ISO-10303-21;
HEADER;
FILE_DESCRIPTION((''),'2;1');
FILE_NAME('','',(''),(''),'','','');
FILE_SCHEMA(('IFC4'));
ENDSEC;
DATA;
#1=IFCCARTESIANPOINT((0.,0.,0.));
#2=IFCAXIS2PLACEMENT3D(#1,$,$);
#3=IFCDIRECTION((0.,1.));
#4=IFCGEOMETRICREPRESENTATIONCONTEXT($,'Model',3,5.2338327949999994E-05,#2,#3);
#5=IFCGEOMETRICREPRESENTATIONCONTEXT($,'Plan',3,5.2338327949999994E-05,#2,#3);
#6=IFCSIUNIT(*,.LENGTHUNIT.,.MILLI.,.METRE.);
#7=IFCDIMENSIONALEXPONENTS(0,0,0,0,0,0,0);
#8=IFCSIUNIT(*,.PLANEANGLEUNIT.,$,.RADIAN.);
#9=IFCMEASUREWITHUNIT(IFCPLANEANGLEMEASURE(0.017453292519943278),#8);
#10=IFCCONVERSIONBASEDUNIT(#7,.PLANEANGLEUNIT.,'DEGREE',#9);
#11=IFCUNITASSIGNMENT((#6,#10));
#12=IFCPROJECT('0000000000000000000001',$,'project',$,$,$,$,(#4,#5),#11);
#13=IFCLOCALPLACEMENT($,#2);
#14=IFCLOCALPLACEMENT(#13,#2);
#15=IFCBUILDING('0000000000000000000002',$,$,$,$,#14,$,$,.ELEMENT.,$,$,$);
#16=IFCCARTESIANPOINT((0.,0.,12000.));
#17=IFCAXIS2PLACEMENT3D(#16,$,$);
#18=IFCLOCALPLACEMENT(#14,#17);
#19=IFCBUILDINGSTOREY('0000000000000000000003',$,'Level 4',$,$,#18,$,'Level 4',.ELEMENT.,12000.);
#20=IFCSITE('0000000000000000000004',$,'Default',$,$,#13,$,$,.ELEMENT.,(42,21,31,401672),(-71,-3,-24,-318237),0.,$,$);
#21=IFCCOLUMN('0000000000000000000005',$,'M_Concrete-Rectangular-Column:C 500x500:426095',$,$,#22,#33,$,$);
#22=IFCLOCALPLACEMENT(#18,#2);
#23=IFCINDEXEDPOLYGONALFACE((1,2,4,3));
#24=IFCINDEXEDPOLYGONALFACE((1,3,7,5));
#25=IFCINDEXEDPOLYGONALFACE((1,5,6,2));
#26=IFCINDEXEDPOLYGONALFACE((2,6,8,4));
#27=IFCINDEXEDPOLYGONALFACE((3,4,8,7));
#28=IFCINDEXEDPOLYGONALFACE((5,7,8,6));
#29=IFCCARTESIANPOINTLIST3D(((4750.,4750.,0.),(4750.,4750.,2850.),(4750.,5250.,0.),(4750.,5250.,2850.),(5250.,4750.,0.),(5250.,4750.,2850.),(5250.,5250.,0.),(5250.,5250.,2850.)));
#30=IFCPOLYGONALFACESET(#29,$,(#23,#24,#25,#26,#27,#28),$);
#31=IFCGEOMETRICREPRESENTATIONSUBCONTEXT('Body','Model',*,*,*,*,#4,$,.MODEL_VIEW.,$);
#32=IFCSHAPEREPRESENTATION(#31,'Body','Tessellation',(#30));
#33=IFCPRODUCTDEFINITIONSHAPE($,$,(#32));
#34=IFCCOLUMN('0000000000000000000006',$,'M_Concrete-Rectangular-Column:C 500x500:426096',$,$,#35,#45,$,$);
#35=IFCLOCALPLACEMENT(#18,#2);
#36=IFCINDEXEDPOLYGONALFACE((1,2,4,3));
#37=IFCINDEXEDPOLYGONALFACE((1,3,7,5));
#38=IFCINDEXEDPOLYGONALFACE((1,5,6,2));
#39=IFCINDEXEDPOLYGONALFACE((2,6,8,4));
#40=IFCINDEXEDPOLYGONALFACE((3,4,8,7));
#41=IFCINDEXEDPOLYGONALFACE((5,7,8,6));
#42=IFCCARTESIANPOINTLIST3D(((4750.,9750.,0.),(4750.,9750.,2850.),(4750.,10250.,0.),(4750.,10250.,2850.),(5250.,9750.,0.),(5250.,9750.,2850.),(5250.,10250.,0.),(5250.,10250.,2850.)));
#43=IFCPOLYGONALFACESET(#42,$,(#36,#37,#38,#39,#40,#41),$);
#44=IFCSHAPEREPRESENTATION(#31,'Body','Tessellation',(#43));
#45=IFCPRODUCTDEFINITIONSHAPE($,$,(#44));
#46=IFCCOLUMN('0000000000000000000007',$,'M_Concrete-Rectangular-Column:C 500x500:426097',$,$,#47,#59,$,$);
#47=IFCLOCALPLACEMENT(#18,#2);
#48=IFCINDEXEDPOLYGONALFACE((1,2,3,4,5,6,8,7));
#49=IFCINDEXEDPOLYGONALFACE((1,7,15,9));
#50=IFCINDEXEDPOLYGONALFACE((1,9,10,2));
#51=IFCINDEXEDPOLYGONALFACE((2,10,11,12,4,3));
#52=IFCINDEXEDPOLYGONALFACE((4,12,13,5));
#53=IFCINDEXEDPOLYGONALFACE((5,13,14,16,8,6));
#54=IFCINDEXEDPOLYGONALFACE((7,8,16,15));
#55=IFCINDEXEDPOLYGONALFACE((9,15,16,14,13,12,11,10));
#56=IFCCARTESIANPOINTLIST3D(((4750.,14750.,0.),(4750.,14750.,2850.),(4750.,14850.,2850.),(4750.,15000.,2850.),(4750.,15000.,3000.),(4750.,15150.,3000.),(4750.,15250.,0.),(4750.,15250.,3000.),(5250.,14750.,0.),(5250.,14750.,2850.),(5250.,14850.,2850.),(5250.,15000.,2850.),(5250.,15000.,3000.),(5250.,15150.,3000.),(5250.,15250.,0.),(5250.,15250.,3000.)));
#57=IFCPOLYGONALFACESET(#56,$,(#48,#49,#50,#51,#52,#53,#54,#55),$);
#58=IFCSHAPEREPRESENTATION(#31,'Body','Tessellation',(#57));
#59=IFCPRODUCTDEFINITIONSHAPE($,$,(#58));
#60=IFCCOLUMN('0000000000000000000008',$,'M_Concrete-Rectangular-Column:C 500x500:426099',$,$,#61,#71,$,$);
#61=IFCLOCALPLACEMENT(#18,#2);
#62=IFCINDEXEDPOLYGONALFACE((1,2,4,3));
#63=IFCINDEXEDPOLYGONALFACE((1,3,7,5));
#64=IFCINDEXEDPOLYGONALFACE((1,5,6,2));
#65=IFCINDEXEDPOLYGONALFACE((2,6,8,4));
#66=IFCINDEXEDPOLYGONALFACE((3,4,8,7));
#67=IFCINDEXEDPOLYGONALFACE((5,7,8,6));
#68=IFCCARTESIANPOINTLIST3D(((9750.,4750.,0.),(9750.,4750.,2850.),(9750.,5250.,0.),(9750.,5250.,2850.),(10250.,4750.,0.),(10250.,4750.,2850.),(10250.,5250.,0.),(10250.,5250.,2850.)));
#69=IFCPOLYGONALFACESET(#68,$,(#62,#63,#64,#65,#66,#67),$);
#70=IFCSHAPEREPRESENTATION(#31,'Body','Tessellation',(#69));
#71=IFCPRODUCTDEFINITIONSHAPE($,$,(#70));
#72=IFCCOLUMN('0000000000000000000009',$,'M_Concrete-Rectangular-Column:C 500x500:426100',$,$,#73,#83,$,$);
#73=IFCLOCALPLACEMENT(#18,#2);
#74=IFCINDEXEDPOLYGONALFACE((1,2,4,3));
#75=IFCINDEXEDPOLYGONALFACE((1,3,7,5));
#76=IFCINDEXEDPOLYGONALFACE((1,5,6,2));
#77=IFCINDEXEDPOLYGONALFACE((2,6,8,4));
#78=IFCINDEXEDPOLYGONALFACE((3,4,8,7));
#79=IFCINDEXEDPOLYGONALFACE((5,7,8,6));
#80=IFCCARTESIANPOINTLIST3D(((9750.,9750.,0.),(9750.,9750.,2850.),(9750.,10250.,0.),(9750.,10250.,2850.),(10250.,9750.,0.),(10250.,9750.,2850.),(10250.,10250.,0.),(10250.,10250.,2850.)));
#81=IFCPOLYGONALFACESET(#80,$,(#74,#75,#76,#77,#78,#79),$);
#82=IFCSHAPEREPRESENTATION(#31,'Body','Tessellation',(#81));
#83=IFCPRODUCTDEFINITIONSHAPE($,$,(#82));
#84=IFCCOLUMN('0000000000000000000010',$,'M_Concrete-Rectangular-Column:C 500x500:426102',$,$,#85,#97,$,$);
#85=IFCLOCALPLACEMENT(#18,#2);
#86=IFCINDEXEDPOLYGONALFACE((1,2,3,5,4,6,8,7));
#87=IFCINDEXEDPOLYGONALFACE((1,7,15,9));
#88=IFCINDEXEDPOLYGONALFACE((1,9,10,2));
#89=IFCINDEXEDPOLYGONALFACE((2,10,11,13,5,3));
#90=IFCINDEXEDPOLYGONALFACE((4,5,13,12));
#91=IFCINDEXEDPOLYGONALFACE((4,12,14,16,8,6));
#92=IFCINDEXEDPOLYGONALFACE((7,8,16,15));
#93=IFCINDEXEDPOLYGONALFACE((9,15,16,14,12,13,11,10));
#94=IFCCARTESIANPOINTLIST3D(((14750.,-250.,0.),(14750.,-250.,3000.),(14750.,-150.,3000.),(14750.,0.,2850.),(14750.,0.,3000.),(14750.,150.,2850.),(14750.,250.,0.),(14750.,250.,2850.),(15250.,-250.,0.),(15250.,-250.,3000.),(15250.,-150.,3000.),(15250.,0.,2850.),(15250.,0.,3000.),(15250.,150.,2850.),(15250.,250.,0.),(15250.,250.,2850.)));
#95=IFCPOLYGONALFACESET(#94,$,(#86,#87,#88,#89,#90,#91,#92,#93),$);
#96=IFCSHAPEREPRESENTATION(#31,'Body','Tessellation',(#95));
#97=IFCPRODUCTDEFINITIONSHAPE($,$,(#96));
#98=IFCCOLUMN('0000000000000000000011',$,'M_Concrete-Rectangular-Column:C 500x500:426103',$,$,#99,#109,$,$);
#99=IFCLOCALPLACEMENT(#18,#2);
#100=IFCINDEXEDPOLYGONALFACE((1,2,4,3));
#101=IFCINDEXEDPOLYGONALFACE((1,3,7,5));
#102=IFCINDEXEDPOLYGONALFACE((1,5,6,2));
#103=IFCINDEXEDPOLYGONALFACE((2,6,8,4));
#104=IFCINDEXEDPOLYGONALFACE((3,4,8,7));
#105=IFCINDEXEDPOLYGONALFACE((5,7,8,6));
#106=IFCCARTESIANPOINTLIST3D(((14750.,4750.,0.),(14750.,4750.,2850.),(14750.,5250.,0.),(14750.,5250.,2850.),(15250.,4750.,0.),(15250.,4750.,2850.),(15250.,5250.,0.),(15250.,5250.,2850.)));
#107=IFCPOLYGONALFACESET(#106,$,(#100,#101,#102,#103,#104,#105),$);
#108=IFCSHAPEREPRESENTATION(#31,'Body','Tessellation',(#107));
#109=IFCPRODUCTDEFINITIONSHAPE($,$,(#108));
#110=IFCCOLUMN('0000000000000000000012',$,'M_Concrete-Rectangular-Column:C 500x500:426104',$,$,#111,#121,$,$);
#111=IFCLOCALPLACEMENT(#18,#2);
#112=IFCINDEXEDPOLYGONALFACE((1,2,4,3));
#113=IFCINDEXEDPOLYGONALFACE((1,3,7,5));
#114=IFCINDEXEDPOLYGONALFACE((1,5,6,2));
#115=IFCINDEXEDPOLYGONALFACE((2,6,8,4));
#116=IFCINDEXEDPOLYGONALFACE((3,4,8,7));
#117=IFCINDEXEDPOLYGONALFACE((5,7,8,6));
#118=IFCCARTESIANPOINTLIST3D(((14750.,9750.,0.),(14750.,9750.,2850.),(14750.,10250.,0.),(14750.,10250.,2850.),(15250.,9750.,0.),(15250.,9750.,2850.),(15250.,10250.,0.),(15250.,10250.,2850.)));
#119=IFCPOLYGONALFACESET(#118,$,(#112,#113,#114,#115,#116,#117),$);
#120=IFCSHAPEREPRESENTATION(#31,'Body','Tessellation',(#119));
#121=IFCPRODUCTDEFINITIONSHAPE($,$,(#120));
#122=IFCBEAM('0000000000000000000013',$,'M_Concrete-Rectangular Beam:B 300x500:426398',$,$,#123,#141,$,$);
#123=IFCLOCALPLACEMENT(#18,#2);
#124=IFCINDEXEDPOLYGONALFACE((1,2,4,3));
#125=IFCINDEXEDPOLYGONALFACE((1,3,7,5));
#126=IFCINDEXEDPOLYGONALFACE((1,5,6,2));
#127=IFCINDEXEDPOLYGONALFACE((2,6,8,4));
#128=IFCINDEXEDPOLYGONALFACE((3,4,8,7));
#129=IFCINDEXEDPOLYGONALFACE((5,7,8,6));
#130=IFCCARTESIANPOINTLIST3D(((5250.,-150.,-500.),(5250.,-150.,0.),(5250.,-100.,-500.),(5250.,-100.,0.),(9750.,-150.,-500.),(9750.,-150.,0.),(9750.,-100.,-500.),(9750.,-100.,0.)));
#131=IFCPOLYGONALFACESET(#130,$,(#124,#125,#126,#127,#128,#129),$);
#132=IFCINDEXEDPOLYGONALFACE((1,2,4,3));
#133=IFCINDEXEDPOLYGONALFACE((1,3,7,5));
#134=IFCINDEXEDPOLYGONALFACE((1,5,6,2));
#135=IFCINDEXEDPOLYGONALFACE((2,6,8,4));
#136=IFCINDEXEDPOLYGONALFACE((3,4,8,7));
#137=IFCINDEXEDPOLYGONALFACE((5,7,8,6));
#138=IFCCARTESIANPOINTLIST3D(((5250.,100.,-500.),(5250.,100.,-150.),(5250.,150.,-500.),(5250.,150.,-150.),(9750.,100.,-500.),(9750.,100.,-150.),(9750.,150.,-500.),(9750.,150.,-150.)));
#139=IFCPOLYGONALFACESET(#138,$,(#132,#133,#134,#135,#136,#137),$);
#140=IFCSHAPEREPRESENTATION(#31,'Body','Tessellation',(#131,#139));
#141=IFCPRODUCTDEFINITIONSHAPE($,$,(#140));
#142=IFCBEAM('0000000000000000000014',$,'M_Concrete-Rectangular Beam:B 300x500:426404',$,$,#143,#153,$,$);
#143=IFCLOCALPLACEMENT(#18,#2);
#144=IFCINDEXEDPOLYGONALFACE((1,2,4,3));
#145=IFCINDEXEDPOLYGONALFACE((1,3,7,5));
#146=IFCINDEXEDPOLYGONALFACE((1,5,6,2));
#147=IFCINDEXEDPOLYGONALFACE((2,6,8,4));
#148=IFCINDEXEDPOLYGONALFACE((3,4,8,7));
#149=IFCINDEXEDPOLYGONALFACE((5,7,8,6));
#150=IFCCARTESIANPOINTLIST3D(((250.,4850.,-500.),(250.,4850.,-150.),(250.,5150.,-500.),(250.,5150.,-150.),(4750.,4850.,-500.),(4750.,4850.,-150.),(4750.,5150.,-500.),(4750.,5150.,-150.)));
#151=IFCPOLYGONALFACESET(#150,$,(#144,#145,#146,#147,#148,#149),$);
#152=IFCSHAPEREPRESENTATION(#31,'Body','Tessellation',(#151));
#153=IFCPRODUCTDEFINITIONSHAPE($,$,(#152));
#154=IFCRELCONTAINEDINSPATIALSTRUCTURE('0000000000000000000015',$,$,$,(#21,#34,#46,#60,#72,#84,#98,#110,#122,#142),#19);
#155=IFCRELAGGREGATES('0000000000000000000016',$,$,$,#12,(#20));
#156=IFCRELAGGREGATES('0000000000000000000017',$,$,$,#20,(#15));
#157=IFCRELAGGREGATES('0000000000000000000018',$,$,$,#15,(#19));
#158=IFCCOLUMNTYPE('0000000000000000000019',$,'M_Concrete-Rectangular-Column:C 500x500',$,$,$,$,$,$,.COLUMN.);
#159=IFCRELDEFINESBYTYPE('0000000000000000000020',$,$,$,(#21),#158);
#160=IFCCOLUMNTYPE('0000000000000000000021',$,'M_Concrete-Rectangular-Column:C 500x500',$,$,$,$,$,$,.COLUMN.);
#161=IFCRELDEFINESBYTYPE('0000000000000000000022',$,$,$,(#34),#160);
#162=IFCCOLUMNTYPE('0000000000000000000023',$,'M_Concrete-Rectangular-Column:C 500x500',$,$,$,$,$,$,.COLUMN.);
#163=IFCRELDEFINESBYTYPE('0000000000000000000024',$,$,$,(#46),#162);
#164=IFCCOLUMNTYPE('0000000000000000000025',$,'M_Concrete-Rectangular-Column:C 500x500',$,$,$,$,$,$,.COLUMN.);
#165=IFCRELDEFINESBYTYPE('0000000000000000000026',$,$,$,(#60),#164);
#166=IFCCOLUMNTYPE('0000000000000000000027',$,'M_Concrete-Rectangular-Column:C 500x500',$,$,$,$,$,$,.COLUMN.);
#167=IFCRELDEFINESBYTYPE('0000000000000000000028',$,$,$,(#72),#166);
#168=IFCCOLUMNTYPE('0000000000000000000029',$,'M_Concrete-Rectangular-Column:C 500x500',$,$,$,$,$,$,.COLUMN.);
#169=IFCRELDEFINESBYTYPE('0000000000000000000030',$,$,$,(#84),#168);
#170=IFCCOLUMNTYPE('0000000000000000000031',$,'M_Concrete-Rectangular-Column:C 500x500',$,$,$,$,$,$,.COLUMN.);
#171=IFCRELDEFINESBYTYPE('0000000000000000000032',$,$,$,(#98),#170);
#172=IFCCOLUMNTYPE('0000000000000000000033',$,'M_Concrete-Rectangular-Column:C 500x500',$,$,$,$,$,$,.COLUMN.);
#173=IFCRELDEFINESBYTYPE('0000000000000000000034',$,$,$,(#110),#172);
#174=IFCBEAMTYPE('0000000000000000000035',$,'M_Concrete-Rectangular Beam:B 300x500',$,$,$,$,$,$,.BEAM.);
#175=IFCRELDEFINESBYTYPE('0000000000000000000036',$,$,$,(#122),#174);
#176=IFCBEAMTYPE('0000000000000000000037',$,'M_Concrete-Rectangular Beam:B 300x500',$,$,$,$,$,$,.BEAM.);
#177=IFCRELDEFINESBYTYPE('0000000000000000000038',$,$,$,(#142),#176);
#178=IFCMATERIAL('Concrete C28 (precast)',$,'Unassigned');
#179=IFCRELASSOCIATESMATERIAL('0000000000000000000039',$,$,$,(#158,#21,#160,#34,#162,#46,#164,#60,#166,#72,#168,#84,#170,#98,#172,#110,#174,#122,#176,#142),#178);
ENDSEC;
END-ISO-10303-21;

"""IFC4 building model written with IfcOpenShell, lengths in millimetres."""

from ifc_helpers import new_model, entity, si_unit, converted_unit, direction, frame, origin, place, context, subcontext, project, spatial, indexed_curve, outline, extrude, source, transform, mapped, material, type_object, type_shapes, element, save


model = new_model("IFC4")

# Units and contexts
model_context = context("Model", 3, precision=5.2338327949999994e-05, world=origin(), true_north=direction((0.0, 1.0)))
plan_context = context("Plan", 3, precision=5.2338327949999994e-05, world=origin(), true_north=direction((0.0, 1.0)))
body_context = subcontext(model_context, "Body", "Model", "MODEL_VIEW")
ifc_project = project(units=[si_unit("LENGTHUNIT", "METRE", prefix="MILLI"), converted_unit("PLANEANGLEUNIT", "DEGREE", entity("IfcPlaneAngleMeasure", 0.017453292519943278), si_unit("PLANEANGLEUNIT", "RADIAN"), dimensions=[0, 0, 0, 0, 0, 0, 0])], contexts=[model_context, plan_context])

# Site, building, storey
site_placement = place(None, origin())
site = spatial("IfcSite", under=ifc_project, at=site_placement, Name="Default", CompositionType="ELEMENT", RefLatitude=(42, 21, 31, 401672), RefLongitude=(-71, -3, -24, -318237), RefElevation=0.0)
building_placement = place(site_placement, origin())
building = spatial("IfcBuilding", under=site, at=building_placement, CompositionType="ELEMENT")
storey_placement = place(building_placement, frame((0.0, 0.0, 12000.0)))
storey = spatial("IfcBuildingStorey", under=building, at=storey_placement, Name="Level 4", LongName="Level 4", CompositionType="ELEMENT", Elevation=12000.0)

# Columns
ifc_material = material(Name="Concrete C28 (precast)", Category="Unassigned")
column_type_1 = type_object("IfcColumnType", Name="M_Concrete-Rectangular-Column:C 500x500", PredefinedType="COLUMN", material=ifc_material)
shared_shape_1 = source(origin(), body_context, "Body", "SweptSolid", [
    extrude(outline(indexed_curve([(-250.0, -250.0), (250.0, -250.0), (250.0, 250.0), (-250.0, 250.0), (-250.0, -250.0)], self_intersect=False)), frame((5000.0, 5000.0, 12000.0), z_axis=(0.0, 0.0, 1.0), x_axis=(-1.0, 0.0, 0.0)), (0.0, 0.0, 1.0), 2850.0),
])
type_shapes(column_type_1, [shared_shape_1])
column_1_placement = place(storey_placement, frame((0.0, 0.0, -12000.0)))
element("IfcColumn", 1, at=column_1_placement, inside=storey, type_object=column_type_1, material=ifc_material, Name="M_Concrete-Rectangular-Column:C 500x500:426095", context=body_context, shape_type="MappedRepresentation", body=[
    mapped(shared_shape_1, transform((0.0, 0.0, 0.0), scale=1.0)),
])
column_type_2 = type_object("IfcColumnType", Name="M_Concrete-Rectangular-Column:C 500x500", PredefinedType="COLUMN", material=ifc_material)
shared_shape_2 = source(origin(), body_context, "Body", "SweptSolid", [
    extrude(outline(indexed_curve([(-250.0, -250.0), (250.0, -250.0), (250.0, 250.0), (-250.0, 250.0), (-250.0, -250.0)], self_intersect=False)), frame((5000.0, 10000.0, 12000.0), z_axis=(0.0, 0.0, 1.0), x_axis=(-1.0, 0.0, 0.0)), (0.0, 0.0, 1.0), 2850.0),
])
type_shapes(column_type_2, [shared_shape_2])
column_2_placement = place(storey_placement, frame((0.0, 0.0, -12000.0)))
element("IfcColumn", 2, at=column_2_placement, inside=storey, type_object=column_type_2, material=ifc_material, Name="M_Concrete-Rectangular-Column:C 500x500:426096", context=body_context, shape_type="MappedRepresentation", body=[
    mapped(shared_shape_2, transform((0.0, 0.0, 0.0), scale=1.0)),
])
column_type_3 = type_object("IfcColumnType", Name="M_Concrete-Rectangular-Column:C 500x500", PredefinedType="COLUMN", material=ifc_material)
shared_shape_3 = source(origin(), body_context, "Body", "SweptSolid", [
    extrude(outline(indexed_curve([(-2193.8, -250.0), (806.2, -250.0), (806.2, -150.0), (806.2, 0.0), (656.2, 0.0), (656.2, 150.0), (656.2, 250.0), (-2193.8, 250.0), (-2193.8, -250.0)], self_intersect=False)), frame((4750.0, 15000.0, 14193.8), z_axis=(1.0, 0.0, 0.0), x_axis=(0.0, 0.0, 1.0)), (0.0, 0.0, 1.0), 500.0),
])
type_shapes(column_type_3, [shared_shape_3])
column_3_placement = place(storey_placement, frame((0.0, 0.0, -12000.0)))
element("IfcColumn", 3, at=column_3_placement, inside=storey, type_object=column_type_3, material=ifc_material, Name="M_Concrete-Rectangular-Column:C 500x500:426097", context=body_context, shape_type="MappedRepresentation", body=[
    mapped(shared_shape_3, transform((0.0, 0.0, 0.0), scale=1.0)),
])
column_type_4 = type_object("IfcColumnType", Name="M_Concrete-Rectangular-Column:C 500x500", PredefinedType="COLUMN", material=ifc_material)
shared_shape_4 = source(origin(), body_context, "Body", "SweptSolid", [
    extrude(outline(indexed_curve([(-250.0, -250.0), (250.0, -250.0), (250.0, 250.0), (-250.0, 250.0), (-250.0, -250.0)], self_intersect=False)), frame((10000.0, 5000.0, 12000.0), z_axis=(0.0, 0.0, 1.0), x_axis=(-1.0, 0.0, 0.0)), (0.0, 0.0, 1.0), 2850.0),
])
type_shapes(column_type_4, [shared_shape_4])
column_4_placement = place(storey_placement, frame((0.0, 0.0, -12000.0)))
element("IfcColumn", 4, at=column_4_placement, inside=storey, type_object=column_type_4, material=ifc_material, Name="M_Concrete-Rectangular-Column:C 500x500:426099", context=body_context, shape_type="MappedRepresentation", body=[
    mapped(shared_shape_4, transform((0.0, 0.0, 0.0), scale=1.0)),
])
column_type_5 = type_object("IfcColumnType", Name="M_Concrete-Rectangular-Column:C 500x500", PredefinedType="COLUMN", material=ifc_material)
shared_shape_5 = source(origin(), body_context, "Body", "SweptSolid", [
    extrude(outline(indexed_curve([(-250.0, -250.0), (250.0, -250.0), (250.0, 250.0), (-250.0, 250.0), (-250.0, -250.0)], self_intersect=False)), frame((10000.0, 10000.0, 12000.0), z_axis=(0.0, 0.0, 1.0), x_axis=(-1.0, 0.0, 0.0)), (0.0, 0.0, 1.0), 2850.0),
])
type_shapes(column_type_5, [shared_shape_5])
column_5_placement = place(storey_placement, frame((0.0, 0.0, -12000.0)))
element("IfcColumn", 5, at=column_5_placement, inside=storey, type_object=column_type_5, material=ifc_material, Name="M_Concrete-Rectangular-Column:C 500x500:426100", context=body_context, shape_type="MappedRepresentation", body=[
    mapped(shared_shape_5, transform((0.0, 0.0, 0.0), scale=1.0)),
])
column_type_6 = type_object("IfcColumnType", Name="M_Concrete-Rectangular-Column:C 500x500", PredefinedType="COLUMN", material=ifc_material)
shared_shape_6 = source(origin(), body_context, "Body", "SweptSolid", [
    extrude(outline(indexed_curve([(-2193.7, -250.0), (656.3, -250.0), (656.3, -150.0), (656.2, 0.0), (806.3, 0.0), (806.3, 150.0), (806.3, 250.0), (-2193.7, 250.0), (-2193.7, -250.0)], self_intersect=False)), frame((14750.0, 0.0, 14193.7), z_axis=(1.0, 0.0, 0.0), x_axis=(0.0, 0.0, 1.0)), (0.0, 0.0, 1.0), 500.0),
])
type_shapes(column_type_6, [shared_shape_6])
column_6_placement = place(storey_placement, frame((0.0, 0.0, -12000.0)))
element("IfcColumn", 6, at=column_6_placement, inside=storey, type_object=column_type_6, material=ifc_material, Name="M_Concrete-Rectangular-Column:C 500x500:426102", context=body_context, shape_type="MappedRepresentation", body=[
    mapped(shared_shape_6, transform((0.0, 0.0, 0.0), scale=1.0)),
])
column_type_7 = type_object("IfcColumnType", Name="M_Concrete-Rectangular-Column:C 500x500", PredefinedType="COLUMN", material=ifc_material)
shared_shape_7 = source(origin(), body_context, "Body", "SweptSolid", [
    extrude(outline(indexed_curve([(-250.0, -250.0), (250.0, -250.0), (250.0, 250.0), (-250.0, 250.0), (-250.0, -250.0)], self_intersect=False)), frame((15000.0, 5000.0, 12000.0), z_axis=(0.0, 0.0, 1.0), x_axis=(-1.0, 0.0, 0.0)), (0.0, 0.0, 1.0), 2850.0),
])
type_shapes(column_type_7, [shared_shape_7])
column_7_placement = place(storey_placement, frame((0.0, 0.0, -12000.0)))
element("IfcColumn", 7, at=column_7_placement, inside=storey, type_object=column_type_7, material=ifc_material, Name="M_Concrete-Rectangular-Column:C 500x500:426103", context=body_context, shape_type="MappedRepresentation", body=[
    mapped(shared_shape_7, transform((0.0, 0.0, 0.0), scale=1.0)),
])
column_type_8 = type_object("IfcColumnType", Name="M_Concrete-Rectangular-Column:C 500x500", PredefinedType="COLUMN", material=ifc_material)
shared_shape_8 = source(origin(), body_context, "Body", "SweptSolid", [
    extrude(outline(indexed_curve([(-250.0, -250.0), (250.0, -250.0), (250.0, 250.0), (-250.0, 250.0), (-250.0, -250.0)], self_intersect=False)), frame((15000.0, 10000.0, 12000.0), z_axis=(0.0, 0.0, 1.0), x_axis=(-1.0, 0.0, 0.0)), (0.0, 0.0, 1.0), 2850.0),
])
type_shapes(column_type_8, [shared_shape_8])
column_8_placement = place(storey_placement, frame((0.0, 0.0, -12000.0)))
element("IfcColumn", 8, at=column_8_placement, inside=storey, type_object=column_type_8, material=ifc_material, Name="M_Concrete-Rectangular-Column:C 500x500:426104", context=body_context, shape_type="MappedRepresentation", body=[
    mapped(shared_shape_8, transform((0.0, 0.0, 0.0), scale=1.0)),
])

# Beams
beam_type_1 = type_object("IfcBeamType", Name="M_Concrete-Rectangular Beam:B 300x500", PredefinedType="BEAM", material=ifc_material)
shared_shape_9 = source(origin(), body_context, "Body", "SweptSolid", [
    extrude(outline(indexed_curve([(-250.0, -25.0), (250.0, -25.0), (250.0, 25.0), (-250.0, 25.0), (-250.0, -25.0)], self_intersect=False)), frame((5250.0, -125.0, 11750.0), z_axis=(1.0, 0.0, 0.0), x_axis=(0.0, 0.0, -1.0)), (0.0, 0.0, 1.0), 4500.0),
    extrude(outline(indexed_curve([(-175.0, -25.0), (175.0, -25.0), (175.0, 25.0), (-175.0, 25.0), (-175.0, -25.0)], self_intersect=False)), frame((5250.0, 125.0, 11675.0), z_axis=(1.0, 0.0, 0.0), x_axis=(0.0, 0.0, -1.0)), (0.0, 0.0, 1.0), 4500.0),
])
type_shapes(beam_type_1, [shared_shape_9])
beam_1_placement = place(storey_placement, frame((0.0, 0.0, -12000.0)))
element("IfcBeam", 9, at=beam_1_placement, inside=storey, type_object=beam_type_1, material=ifc_material, Name="M_Concrete-Rectangular Beam:B 300x500:426398", context=body_context, shape_type="MappedRepresentation", body=[
    mapped(shared_shape_9, transform((0.0, 0.0, 0.0), scale=1.0)),
])
beam_type_2 = type_object("IfcBeamType", Name="M_Concrete-Rectangular Beam:B 300x500", PredefinedType="BEAM", material=ifc_material)
shared_shape_10 = source(origin(), body_context, "Body", "SweptSolid", [
    extrude(outline(indexed_curve([(-175.0, -150.0), (175.0, -150.0), (175.0, 150.0), (-175.0, 150.0), (-175.0, -150.0)], self_intersect=False)), frame((250.0, 5000.0, 11675.0), z_axis=(1.0, 0.0, 0.0), x_axis=(0.0, 0.0, -1.0)), (0.0, 0.0, 1.0), 4500.0),
])
type_shapes(beam_type_2, [shared_shape_10])
beam_2_placement = place(storey_placement, frame((0.0, 0.0, -12000.0)))
element("IfcBeam", 10, at=beam_2_placement, inside=storey, type_object=beam_type_2, material=ifc_material, Name="M_Concrete-Rectangular Beam:B 300x500:426404", context=body_context, shape_type="MappedRepresentation", body=[
    mapped(shared_shape_10, transform((0.0, 0.0, 0.0), scale=1.0)),
])

save(model, "model.ifc")
